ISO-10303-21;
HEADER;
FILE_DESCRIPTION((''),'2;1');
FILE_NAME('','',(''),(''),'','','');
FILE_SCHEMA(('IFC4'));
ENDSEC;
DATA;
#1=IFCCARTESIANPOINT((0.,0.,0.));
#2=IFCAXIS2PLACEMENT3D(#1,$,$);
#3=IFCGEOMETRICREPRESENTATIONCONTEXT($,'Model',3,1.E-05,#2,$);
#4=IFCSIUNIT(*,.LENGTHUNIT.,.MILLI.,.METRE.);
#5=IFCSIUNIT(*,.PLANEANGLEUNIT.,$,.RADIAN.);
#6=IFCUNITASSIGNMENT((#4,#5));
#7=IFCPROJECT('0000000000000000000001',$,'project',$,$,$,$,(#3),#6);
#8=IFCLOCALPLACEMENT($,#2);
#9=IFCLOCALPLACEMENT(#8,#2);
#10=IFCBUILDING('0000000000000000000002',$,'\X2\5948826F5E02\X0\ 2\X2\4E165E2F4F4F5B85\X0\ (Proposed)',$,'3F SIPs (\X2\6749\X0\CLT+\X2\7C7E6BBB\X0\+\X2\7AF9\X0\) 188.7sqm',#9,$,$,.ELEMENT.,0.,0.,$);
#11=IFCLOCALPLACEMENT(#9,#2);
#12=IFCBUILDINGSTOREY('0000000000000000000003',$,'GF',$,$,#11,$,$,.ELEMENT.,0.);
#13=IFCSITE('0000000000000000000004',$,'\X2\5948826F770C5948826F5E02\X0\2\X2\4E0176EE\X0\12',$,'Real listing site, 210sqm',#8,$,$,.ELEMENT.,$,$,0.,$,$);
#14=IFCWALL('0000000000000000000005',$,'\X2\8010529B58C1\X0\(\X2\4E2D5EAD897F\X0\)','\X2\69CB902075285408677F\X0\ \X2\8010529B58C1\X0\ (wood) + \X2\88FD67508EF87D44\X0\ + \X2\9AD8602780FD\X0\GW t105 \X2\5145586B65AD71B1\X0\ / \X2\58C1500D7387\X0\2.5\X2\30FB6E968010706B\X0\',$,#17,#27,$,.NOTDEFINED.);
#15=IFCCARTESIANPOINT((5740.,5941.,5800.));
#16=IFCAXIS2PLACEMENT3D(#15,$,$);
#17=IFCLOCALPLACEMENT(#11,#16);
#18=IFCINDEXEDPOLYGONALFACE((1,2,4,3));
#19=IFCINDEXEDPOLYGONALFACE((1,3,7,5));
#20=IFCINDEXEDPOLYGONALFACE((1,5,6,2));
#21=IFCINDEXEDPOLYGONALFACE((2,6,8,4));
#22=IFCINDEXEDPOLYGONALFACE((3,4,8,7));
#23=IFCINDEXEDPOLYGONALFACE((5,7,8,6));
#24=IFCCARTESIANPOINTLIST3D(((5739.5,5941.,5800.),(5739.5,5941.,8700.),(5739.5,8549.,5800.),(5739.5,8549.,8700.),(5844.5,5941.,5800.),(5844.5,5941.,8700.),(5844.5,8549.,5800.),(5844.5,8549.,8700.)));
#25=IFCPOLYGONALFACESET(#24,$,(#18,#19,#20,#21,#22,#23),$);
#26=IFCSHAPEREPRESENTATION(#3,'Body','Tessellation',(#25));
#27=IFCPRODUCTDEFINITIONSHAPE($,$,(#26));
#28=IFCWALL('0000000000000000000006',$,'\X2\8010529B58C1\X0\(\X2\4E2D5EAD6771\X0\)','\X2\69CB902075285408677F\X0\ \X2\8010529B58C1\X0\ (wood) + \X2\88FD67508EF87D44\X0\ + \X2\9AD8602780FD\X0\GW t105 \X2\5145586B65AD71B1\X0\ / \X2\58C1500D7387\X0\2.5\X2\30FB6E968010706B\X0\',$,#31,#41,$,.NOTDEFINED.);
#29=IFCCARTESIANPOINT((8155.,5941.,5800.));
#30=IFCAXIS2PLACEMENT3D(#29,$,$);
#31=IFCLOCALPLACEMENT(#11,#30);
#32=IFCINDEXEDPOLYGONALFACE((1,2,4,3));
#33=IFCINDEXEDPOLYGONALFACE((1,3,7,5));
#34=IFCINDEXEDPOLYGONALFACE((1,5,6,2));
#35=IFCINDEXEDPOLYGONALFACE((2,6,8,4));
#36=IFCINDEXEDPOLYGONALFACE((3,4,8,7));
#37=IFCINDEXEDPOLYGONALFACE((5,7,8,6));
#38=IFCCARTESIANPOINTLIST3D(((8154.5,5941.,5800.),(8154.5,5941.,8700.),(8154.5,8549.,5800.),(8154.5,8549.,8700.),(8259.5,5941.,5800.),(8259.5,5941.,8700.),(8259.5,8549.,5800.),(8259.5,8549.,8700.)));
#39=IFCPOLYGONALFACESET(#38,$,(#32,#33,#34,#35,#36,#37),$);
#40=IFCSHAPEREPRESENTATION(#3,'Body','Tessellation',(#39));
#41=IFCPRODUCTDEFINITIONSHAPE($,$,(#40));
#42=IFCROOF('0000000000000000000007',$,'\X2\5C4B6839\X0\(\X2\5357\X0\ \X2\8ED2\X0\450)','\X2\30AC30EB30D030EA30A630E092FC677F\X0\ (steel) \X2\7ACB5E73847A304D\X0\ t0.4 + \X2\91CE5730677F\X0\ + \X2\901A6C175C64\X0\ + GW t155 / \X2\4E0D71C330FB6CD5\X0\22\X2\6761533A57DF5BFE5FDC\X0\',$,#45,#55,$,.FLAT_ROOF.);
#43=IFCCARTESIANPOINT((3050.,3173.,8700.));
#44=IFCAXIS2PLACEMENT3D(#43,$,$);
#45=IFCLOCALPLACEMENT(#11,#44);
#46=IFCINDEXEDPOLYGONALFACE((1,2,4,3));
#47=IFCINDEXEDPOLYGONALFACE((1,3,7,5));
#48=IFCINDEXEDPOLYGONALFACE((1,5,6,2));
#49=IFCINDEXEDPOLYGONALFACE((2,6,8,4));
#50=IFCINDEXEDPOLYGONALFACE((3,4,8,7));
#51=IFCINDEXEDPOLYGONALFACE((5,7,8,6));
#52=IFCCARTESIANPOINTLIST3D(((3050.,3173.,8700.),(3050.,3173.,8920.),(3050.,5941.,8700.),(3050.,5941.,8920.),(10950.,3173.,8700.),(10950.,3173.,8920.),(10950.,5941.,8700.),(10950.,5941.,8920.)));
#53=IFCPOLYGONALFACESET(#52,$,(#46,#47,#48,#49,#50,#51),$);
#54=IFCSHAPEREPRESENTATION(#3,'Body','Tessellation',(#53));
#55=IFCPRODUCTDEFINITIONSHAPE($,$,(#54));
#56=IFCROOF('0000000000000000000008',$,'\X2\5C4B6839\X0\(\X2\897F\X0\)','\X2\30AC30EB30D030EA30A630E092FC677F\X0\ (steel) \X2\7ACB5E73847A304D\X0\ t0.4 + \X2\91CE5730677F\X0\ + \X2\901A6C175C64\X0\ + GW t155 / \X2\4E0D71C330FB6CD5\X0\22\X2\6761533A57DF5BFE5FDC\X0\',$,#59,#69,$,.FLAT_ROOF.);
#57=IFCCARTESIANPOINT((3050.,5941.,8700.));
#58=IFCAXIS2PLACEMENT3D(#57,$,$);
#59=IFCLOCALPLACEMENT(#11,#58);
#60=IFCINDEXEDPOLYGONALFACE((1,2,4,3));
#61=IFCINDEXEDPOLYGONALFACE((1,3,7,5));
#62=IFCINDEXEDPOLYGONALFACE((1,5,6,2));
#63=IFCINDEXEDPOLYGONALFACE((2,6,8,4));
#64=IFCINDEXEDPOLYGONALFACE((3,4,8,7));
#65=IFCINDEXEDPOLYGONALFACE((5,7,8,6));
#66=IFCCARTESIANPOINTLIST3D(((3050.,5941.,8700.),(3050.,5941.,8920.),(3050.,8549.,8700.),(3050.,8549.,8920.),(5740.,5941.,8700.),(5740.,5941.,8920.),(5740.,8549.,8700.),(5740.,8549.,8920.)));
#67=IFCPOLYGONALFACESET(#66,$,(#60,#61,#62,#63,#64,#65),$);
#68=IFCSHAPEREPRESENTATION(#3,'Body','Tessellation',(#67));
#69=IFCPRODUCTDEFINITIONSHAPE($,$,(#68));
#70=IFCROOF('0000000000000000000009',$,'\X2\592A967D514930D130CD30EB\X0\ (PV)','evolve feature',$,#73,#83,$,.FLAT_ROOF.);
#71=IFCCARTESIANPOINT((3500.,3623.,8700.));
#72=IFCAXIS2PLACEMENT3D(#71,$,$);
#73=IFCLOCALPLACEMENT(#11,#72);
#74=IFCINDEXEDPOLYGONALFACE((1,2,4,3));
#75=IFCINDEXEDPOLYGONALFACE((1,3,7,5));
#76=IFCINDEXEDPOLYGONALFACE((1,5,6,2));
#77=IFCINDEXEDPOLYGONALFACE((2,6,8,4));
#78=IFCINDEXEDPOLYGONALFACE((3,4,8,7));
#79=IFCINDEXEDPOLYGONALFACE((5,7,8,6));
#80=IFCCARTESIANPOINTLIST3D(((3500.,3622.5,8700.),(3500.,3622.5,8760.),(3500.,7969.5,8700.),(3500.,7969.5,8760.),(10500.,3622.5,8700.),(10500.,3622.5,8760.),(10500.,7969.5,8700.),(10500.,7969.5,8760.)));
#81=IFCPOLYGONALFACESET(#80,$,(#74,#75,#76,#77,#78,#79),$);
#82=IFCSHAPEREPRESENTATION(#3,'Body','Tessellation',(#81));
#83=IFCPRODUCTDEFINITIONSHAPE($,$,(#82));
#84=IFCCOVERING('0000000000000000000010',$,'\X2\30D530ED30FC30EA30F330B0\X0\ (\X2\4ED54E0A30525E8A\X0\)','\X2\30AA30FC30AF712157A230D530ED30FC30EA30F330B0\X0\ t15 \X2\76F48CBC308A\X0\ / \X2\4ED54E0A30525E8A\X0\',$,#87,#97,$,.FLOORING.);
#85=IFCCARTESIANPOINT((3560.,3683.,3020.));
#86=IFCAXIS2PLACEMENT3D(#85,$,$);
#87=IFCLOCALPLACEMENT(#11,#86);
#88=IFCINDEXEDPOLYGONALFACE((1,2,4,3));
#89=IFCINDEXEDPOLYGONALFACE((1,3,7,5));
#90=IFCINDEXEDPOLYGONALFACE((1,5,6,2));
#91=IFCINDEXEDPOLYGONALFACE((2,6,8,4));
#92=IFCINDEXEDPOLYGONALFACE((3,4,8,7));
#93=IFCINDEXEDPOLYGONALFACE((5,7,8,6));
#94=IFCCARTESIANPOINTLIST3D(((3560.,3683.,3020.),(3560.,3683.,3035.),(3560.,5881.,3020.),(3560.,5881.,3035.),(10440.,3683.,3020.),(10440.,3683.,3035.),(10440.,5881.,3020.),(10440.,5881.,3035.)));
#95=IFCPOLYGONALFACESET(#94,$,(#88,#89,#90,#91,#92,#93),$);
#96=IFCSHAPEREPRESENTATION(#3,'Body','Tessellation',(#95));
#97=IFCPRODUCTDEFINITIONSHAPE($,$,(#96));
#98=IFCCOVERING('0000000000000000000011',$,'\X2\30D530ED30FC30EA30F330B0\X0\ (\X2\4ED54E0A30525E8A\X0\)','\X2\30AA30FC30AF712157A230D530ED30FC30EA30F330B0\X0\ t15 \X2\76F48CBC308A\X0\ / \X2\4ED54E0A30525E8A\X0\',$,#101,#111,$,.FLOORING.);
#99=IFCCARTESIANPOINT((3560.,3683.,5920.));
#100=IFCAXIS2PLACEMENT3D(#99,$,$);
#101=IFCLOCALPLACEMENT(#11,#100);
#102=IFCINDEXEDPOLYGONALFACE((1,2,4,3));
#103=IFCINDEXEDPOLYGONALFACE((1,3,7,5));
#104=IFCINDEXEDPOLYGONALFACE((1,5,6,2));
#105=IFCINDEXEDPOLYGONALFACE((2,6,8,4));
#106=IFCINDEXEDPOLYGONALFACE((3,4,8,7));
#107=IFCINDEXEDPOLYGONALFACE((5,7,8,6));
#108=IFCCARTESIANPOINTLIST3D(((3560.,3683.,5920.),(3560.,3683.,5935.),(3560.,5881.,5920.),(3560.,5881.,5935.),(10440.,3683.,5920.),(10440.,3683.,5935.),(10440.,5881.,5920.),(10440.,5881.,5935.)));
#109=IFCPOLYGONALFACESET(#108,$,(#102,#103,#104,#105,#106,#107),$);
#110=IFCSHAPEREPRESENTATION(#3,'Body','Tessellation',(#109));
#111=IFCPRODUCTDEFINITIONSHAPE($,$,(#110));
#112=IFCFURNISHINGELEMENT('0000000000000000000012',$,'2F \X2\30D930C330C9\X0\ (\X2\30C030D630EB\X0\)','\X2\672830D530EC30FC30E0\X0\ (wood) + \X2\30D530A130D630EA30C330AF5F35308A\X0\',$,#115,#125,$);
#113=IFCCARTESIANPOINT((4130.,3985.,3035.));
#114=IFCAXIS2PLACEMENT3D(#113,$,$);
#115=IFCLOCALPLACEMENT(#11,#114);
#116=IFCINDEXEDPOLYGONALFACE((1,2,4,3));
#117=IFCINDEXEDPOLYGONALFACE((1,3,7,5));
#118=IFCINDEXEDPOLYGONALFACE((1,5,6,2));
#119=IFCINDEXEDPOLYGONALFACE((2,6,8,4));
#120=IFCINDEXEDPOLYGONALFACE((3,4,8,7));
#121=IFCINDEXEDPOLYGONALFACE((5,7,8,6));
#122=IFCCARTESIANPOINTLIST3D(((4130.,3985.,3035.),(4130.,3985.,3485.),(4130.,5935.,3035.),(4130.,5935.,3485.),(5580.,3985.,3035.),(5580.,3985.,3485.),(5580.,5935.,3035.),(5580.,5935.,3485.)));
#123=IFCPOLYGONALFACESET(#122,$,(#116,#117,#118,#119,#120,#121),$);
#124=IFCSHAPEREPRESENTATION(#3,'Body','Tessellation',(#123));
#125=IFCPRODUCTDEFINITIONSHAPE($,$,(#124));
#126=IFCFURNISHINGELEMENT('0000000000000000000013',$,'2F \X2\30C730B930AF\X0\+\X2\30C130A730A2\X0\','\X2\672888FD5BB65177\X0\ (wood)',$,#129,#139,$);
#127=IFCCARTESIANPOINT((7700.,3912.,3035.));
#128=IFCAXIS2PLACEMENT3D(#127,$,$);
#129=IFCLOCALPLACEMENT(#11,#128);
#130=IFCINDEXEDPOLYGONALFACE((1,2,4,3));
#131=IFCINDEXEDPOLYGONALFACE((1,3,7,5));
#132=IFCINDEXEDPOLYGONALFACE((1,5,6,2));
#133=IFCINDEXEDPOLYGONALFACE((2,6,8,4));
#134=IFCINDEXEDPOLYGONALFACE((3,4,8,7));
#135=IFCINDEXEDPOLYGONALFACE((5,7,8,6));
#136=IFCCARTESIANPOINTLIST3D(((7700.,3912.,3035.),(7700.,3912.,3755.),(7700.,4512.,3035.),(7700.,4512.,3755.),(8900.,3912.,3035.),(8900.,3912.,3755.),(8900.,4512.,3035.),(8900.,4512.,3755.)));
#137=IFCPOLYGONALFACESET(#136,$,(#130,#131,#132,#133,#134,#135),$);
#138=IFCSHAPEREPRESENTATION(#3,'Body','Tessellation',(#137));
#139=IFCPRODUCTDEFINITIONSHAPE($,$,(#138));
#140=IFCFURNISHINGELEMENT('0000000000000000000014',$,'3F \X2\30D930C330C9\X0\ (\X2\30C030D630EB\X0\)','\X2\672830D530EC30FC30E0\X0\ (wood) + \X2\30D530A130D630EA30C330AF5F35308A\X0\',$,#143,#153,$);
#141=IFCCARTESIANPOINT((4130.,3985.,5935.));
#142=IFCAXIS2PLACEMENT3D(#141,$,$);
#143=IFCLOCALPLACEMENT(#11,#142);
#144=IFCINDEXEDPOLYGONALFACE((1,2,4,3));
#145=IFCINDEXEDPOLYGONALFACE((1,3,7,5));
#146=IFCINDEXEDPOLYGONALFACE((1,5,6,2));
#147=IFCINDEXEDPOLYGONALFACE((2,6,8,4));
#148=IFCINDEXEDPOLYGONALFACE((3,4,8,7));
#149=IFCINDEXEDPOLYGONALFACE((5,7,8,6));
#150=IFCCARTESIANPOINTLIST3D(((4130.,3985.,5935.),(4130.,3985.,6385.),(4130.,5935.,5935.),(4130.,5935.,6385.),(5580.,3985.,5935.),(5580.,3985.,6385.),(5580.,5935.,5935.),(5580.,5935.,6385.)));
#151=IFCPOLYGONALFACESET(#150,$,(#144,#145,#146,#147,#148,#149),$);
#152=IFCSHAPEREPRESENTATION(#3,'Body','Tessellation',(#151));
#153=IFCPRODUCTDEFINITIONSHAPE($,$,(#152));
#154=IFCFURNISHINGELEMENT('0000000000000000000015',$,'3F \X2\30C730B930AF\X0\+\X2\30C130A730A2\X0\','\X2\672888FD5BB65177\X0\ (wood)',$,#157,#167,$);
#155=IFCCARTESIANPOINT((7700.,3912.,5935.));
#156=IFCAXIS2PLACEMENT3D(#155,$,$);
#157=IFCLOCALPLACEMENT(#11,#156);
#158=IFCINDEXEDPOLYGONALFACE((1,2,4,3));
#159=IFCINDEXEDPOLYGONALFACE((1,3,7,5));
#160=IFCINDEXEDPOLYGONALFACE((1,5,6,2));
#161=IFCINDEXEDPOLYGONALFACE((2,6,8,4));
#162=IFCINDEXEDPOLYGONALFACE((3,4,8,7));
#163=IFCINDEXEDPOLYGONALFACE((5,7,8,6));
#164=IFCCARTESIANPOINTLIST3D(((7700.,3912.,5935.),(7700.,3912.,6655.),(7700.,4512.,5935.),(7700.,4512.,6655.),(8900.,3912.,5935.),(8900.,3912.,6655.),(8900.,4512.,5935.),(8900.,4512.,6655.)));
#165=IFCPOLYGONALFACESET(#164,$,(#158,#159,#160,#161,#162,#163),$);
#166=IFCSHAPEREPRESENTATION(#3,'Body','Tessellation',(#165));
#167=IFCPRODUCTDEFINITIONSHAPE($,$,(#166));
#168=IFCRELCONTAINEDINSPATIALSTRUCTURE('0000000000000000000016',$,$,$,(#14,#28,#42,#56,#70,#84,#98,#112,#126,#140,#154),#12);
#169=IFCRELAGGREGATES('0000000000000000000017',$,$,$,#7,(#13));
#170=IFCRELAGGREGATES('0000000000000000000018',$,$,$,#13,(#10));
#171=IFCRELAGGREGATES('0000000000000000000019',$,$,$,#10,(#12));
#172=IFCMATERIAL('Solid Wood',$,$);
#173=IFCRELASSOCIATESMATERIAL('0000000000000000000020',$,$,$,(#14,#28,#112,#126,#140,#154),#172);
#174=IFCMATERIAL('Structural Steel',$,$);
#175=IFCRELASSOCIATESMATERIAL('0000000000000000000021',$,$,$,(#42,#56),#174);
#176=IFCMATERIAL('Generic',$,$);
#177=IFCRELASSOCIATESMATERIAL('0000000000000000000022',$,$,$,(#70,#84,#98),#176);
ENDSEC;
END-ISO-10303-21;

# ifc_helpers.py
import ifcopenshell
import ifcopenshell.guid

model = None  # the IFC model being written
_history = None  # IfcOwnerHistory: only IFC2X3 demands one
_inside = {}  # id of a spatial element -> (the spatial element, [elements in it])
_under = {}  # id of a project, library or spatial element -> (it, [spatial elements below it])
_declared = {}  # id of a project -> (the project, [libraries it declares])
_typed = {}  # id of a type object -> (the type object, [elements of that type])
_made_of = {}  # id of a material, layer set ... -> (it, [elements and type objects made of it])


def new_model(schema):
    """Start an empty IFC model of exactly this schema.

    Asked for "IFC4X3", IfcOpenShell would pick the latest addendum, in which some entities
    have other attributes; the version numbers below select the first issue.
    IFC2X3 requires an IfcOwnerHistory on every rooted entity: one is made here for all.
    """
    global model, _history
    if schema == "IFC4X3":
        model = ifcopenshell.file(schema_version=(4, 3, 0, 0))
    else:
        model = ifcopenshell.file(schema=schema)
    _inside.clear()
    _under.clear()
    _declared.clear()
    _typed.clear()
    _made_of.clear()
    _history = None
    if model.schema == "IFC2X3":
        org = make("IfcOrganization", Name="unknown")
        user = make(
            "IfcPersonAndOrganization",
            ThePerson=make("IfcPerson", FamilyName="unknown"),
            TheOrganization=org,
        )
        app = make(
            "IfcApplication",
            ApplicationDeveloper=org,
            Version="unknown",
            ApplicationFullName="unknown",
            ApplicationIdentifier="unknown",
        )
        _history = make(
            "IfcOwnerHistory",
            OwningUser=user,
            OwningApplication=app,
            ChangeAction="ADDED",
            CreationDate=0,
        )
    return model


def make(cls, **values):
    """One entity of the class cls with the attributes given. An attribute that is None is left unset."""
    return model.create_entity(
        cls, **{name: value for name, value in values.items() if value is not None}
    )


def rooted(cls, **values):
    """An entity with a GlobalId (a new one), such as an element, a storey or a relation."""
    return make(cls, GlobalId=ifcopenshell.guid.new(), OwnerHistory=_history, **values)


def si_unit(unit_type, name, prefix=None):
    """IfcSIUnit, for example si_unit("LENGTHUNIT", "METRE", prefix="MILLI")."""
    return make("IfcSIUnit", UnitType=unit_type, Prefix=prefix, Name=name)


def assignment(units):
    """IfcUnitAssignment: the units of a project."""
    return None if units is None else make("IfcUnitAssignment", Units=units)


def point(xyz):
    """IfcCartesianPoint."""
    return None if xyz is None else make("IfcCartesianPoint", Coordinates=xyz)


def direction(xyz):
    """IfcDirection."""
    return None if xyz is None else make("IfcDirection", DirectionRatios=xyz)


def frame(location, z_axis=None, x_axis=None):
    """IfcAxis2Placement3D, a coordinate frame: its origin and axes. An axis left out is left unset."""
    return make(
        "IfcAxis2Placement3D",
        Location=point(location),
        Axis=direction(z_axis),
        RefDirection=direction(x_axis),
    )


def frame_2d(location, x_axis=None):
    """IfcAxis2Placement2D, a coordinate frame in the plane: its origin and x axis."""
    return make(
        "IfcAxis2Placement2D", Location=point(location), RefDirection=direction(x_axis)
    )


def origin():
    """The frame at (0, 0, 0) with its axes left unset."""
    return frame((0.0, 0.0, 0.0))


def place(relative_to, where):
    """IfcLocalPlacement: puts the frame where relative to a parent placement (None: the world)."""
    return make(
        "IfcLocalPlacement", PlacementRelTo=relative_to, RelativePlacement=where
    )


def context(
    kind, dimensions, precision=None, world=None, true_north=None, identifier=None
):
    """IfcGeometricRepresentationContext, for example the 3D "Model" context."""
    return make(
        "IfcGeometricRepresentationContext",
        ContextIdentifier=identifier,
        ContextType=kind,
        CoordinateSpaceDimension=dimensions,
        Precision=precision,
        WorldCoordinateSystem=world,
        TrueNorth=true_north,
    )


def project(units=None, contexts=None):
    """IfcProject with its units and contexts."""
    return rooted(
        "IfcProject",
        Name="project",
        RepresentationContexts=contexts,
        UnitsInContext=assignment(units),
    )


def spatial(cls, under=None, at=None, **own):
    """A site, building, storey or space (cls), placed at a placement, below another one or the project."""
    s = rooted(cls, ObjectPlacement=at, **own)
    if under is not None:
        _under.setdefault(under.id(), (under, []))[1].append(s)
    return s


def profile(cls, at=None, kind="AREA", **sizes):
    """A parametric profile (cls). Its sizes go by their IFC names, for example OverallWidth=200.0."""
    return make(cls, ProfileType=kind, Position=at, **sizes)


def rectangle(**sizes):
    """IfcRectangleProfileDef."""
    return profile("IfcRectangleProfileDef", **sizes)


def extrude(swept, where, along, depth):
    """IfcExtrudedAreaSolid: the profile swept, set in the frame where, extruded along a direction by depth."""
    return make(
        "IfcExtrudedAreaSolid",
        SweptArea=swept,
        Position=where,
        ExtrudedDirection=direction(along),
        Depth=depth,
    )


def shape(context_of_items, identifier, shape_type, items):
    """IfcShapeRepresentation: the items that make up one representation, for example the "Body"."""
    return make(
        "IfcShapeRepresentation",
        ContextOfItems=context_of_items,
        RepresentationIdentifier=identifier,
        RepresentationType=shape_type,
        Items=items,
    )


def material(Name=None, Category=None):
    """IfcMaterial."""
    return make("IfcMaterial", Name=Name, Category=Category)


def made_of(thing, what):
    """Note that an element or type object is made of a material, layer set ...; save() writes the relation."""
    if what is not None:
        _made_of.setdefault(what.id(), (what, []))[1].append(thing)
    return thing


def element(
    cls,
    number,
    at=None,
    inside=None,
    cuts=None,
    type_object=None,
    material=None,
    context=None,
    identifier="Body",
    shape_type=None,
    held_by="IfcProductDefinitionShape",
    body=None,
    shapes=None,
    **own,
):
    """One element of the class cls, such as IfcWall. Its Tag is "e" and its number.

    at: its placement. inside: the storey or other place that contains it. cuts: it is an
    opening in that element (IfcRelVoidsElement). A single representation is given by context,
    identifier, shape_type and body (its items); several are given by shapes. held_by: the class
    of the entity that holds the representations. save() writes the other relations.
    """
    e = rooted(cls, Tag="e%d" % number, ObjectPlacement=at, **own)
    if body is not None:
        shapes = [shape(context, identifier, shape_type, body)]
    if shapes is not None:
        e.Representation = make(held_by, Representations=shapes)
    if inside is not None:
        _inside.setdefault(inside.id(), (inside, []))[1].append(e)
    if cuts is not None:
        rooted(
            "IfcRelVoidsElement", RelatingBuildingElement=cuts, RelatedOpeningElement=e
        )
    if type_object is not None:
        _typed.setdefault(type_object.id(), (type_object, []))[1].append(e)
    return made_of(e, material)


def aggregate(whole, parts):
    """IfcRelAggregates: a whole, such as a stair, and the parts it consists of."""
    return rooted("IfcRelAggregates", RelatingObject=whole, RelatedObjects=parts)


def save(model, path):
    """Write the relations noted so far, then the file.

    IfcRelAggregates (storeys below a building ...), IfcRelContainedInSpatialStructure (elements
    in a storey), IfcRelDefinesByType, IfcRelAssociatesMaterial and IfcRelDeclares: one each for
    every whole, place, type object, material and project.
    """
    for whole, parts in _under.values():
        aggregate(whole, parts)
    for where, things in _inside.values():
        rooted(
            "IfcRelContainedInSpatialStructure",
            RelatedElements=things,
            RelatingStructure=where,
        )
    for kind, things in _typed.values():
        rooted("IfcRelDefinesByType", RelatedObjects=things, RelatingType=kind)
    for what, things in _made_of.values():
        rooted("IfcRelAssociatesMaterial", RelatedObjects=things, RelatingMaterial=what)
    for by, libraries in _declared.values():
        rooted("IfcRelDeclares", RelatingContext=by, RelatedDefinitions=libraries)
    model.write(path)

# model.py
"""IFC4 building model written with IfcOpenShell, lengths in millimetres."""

from ifc_helpers import new_model, si_unit, frame, frame_2d, origin, place, context, project, spatial, rectangle, extrude, material, element, save


model = new_model("IFC4")

# Units and contexts
model_context = context("Model", 3, precision=1e-05, world=origin())
ifc_project = project(units=[si_unit("LENGTHUNIT", "METRE", prefix="MILLI"), si_unit("PLANEANGLEUNIT", "RADIAN")], contexts=[model_context])

# Site, building, storey
site_placement = place(None, origin())
site = spatial("IfcSite", under=ifc_project, at=site_placement, Name="奈良県奈良市2丁目12", ObjectType="Real listing site, 210sqm", CompositionType="ELEMENT", RefElevation=0.0)
building_placement = place(site_placement, origin())
building = spatial("IfcBuilding", under=site, at=building_placement, Name="奈良市 2世帯住宅 (Proposed)", ObjectType="3F SIPs (杉CLT+籾殻+竹) 188.7sqm", CompositionType="ELEMENT", ElevationOfRefHeight=0.0, ElevationOfTerrain=0.0)
storey_placement = place(building_placement, origin())
storey = spatial("IfcBuildingStorey", under=building, at=storey_placement, Name="GF", CompositionType="ELEMENT", Elevation=0.0)

# Shared definitions
ifc_material_1 = material(Name="Solid Wood")

# Walls
wall_1_placement = place(storey_placement, frame((5740.0, 5941.0, 5800.0)))
element("IfcWall", 1, at=wall_1_placement, inside=storey, material=ifc_material_1, Name="耐力壁(中庭西)", Description="構造用合板 耐力壁 (wood) + 製材軸組 + 高性能GW t105 充填断熱 / 壁倍率2.5・準耐火", PredefinedType="NOTDEFINED", context=model_context, shape_type="SweptSolid", body=[
    extrude(rectangle(XDim=105.0, YDim=2608.0, at=frame_2d((52.0, 1304.0))), frame((5740.0, 5941.0, 5800.0)), (0.0, 0.0, 1.0), 2900.0),
])
wall_2_placement = place(storey_placement, frame((8155.0, 5941.0, 5800.0)))
element("IfcWall", 2, at=wall_2_placement, inside=storey, material=ifc_material_1, Name="耐力壁(中庭東)", Description="構造用合板 耐力壁 (wood) + 製材軸組 + 高性能GW t105 充填断熱 / 壁倍率2.5・準耐火", PredefinedType="NOTDEFINED", context=model_context, shape_type="SweptSolid", body=[
    extrude(rectangle(XDim=105.0, YDim=2608.0, at=frame_2d((52.0, 1304.0))), frame((8155.0, 5941.0, 5800.0)), (0.0, 0.0, 1.0), 2900.0),
])

# Roofs
ifc_material_2 = material(Name="Structural Steel")
roof_1_placement = place(storey_placement, frame((3050.0, 3173.0, 8700.0)))
element("IfcRoof", 3, at=roof_1_placement, inside=storey, material=ifc_material_2, Name="屋根(南 軒450)", Description="ガルバリウム鋼板 (steel) 立平葺き t0.4 + 野地板 + 通気層 + GW t155 / 不燃・法22条区域対応", PredefinedType="FLAT_ROOF", context=model_context, shape_type="SweptSolid", body=[
    extrude(rectangle(XDim=7900.0, YDim=2768.0, at=frame_2d((3950.0, 1384.0))), frame((3050.0, 3173.0, 8700.0)), (0.0, 0.0, 1.0), 220.0),
])
roof_2_placement = place(storey_placement, frame((3050.0, 5941.0, 8700.0)))
element("IfcRoof", 4, at=roof_2_placement, inside=storey, material=ifc_material_2, Name="屋根(西)", Description="ガルバリウム鋼板 (steel) 立平葺き t0.4 + 野地板 + 通気層 + GW t155 / 不燃・法22条区域対応", PredefinedType="FLAT_ROOF", context=model_context, shape_type="SweptSolid", body=[
    extrude(rectangle(XDim=2690.0, YDim=2608.0, at=frame_2d((1345.0, 1304.0))), frame((3050.0, 5941.0, 8700.0)), (0.0, 0.0, 1.0), 220.0),
])
ifc_material_3 = material(Name="Generic")
roof_3_placement = place(storey_placement, frame((3500.0, 3623.0, 8700.0)))
element("IfcRoof", 5, at=roof_3_placement, inside=storey, material=ifc_material_3, Name="太陽光パネル (PV)", Description="evolve feature", PredefinedType="FLAT_ROOF", context=model_context, shape_type="SweptSolid", body=[
    extrude(rectangle(XDim=7000.0, YDim=4347.0, at=frame_2d((3500.0, 2173.0))), frame((3500.0, 3623.0, 8700.0)), (0.0, 0.0, 1.0), 60.0),
])

# Coverings
covering_1_placement = place(storey_placement, frame((3560.0, 3683.0, 3020.0)))
element("IfcCovering", 6, at=covering_1_placement, inside=storey, material=ifc_material_3, Name="フローリング (仕上げ床)", Description="オーク無垢フローリング t15 直貼り / 仕上げ床", PredefinedType="FLOORING", context=model_context, shape_type="SweptSolid", body=[
    extrude(rectangle(XDim=6880.0, YDim=2198.0, at=frame_2d((3440.0, 1099.0))), frame((3560.0, 3683.0, 3020.0)), (0.0, 0.0, 1.0), 15.0),
])
covering_2_placement = place(storey_placement, frame((3560.0, 3683.0, 5920.0)))
element("IfcCovering", 7, at=covering_2_placement, inside=storey, material=ifc_material_3, Name="フローリング (仕上げ床)", Description="オーク無垢フローリング t15 直貼り / 仕上げ床", PredefinedType="FLOORING", context=model_context, shape_type="SweptSolid", body=[
    extrude(rectangle(XDim=6880.0, YDim=2198.0, at=frame_2d((3440.0, 1099.0))), frame((3560.0, 3683.0, 5920.0)), (0.0, 0.0, 1.0), 15.0),
])

# Furnishing elements
furnishing_1_placement = place(storey_placement, frame((4130.0, 3985.0, 3035.0)))
element("IfcFurnishingElement", 8, at=furnishing_1_placement, inside=storey, material=ifc_material_1, Name="2F ベッド (ダブル)", Description="木フレーム (wood) + ファブリック張り", context=model_context, shape_type="SweptSolid", body=[
    extrude(rectangle(XDim=1450.0, YDim=1950.0, at=frame_2d((725.0, 975.0))), frame((4130.0, 3985.0, 3035.0)), (0.0, 0.0, 1.0), 450.0),
])
furnishing_2_placement = place(storey_placement, frame((7700.0, 3912.0, 3035.0)))
element("IfcFurnishingElement", 9, at=furnishing_2_placement, inside=storey, material=ifc_material_1, Name="2F デスク+チェア", Description="木製家具 (wood)", context=model_context, shape_type="SweptSolid", body=[
    extrude(rectangle(XDim=1200.0, YDim=600.0, at=frame_2d((600.0, 300.0))), frame((7700.0, 3912.0, 3035.0)), (0.0, 0.0, 1.0), 720.0),
])
furnishing_3_placement = place(storey_placement, frame((4130.0, 3985.0, 5935.0)))
element("IfcFurnishingElement", 10, at=furnishing_3_placement, inside=storey, material=ifc_material_1, Name="3F ベッド (ダブル)", Description="木フレーム (wood) + ファブリック張り", context=model_context, shape_type="SweptSolid", body=[
    extrude(rectangle(XDim=1450.0, YDim=1950.0, at=frame_2d((725.0, 975.0))), frame((4130.0, 3985.0, 5935.0)), (0.0, 0.0, 1.0), 450.0),
])
furnishing_4_placement = place(storey_placement, frame((7700.0, 3912.0, 5935.0)))
element("IfcFurnishingElement", 11, at=furnishing_4_placement, inside=storey, material=ifc_material_1, Name="3F デスク+チェア", Description="木製家具 (wood)", context=model_context, shape_type="SweptSolid", body=[
    extrude(rectangle(XDim=1200.0, YDim=600.0, at=frame_2d((600.0, 300.0))), frame((7700.0, 3912.0, 5935.0)), (0.0, 0.0, 1.0), 720.0),
])

save(model, "model.ifc")
